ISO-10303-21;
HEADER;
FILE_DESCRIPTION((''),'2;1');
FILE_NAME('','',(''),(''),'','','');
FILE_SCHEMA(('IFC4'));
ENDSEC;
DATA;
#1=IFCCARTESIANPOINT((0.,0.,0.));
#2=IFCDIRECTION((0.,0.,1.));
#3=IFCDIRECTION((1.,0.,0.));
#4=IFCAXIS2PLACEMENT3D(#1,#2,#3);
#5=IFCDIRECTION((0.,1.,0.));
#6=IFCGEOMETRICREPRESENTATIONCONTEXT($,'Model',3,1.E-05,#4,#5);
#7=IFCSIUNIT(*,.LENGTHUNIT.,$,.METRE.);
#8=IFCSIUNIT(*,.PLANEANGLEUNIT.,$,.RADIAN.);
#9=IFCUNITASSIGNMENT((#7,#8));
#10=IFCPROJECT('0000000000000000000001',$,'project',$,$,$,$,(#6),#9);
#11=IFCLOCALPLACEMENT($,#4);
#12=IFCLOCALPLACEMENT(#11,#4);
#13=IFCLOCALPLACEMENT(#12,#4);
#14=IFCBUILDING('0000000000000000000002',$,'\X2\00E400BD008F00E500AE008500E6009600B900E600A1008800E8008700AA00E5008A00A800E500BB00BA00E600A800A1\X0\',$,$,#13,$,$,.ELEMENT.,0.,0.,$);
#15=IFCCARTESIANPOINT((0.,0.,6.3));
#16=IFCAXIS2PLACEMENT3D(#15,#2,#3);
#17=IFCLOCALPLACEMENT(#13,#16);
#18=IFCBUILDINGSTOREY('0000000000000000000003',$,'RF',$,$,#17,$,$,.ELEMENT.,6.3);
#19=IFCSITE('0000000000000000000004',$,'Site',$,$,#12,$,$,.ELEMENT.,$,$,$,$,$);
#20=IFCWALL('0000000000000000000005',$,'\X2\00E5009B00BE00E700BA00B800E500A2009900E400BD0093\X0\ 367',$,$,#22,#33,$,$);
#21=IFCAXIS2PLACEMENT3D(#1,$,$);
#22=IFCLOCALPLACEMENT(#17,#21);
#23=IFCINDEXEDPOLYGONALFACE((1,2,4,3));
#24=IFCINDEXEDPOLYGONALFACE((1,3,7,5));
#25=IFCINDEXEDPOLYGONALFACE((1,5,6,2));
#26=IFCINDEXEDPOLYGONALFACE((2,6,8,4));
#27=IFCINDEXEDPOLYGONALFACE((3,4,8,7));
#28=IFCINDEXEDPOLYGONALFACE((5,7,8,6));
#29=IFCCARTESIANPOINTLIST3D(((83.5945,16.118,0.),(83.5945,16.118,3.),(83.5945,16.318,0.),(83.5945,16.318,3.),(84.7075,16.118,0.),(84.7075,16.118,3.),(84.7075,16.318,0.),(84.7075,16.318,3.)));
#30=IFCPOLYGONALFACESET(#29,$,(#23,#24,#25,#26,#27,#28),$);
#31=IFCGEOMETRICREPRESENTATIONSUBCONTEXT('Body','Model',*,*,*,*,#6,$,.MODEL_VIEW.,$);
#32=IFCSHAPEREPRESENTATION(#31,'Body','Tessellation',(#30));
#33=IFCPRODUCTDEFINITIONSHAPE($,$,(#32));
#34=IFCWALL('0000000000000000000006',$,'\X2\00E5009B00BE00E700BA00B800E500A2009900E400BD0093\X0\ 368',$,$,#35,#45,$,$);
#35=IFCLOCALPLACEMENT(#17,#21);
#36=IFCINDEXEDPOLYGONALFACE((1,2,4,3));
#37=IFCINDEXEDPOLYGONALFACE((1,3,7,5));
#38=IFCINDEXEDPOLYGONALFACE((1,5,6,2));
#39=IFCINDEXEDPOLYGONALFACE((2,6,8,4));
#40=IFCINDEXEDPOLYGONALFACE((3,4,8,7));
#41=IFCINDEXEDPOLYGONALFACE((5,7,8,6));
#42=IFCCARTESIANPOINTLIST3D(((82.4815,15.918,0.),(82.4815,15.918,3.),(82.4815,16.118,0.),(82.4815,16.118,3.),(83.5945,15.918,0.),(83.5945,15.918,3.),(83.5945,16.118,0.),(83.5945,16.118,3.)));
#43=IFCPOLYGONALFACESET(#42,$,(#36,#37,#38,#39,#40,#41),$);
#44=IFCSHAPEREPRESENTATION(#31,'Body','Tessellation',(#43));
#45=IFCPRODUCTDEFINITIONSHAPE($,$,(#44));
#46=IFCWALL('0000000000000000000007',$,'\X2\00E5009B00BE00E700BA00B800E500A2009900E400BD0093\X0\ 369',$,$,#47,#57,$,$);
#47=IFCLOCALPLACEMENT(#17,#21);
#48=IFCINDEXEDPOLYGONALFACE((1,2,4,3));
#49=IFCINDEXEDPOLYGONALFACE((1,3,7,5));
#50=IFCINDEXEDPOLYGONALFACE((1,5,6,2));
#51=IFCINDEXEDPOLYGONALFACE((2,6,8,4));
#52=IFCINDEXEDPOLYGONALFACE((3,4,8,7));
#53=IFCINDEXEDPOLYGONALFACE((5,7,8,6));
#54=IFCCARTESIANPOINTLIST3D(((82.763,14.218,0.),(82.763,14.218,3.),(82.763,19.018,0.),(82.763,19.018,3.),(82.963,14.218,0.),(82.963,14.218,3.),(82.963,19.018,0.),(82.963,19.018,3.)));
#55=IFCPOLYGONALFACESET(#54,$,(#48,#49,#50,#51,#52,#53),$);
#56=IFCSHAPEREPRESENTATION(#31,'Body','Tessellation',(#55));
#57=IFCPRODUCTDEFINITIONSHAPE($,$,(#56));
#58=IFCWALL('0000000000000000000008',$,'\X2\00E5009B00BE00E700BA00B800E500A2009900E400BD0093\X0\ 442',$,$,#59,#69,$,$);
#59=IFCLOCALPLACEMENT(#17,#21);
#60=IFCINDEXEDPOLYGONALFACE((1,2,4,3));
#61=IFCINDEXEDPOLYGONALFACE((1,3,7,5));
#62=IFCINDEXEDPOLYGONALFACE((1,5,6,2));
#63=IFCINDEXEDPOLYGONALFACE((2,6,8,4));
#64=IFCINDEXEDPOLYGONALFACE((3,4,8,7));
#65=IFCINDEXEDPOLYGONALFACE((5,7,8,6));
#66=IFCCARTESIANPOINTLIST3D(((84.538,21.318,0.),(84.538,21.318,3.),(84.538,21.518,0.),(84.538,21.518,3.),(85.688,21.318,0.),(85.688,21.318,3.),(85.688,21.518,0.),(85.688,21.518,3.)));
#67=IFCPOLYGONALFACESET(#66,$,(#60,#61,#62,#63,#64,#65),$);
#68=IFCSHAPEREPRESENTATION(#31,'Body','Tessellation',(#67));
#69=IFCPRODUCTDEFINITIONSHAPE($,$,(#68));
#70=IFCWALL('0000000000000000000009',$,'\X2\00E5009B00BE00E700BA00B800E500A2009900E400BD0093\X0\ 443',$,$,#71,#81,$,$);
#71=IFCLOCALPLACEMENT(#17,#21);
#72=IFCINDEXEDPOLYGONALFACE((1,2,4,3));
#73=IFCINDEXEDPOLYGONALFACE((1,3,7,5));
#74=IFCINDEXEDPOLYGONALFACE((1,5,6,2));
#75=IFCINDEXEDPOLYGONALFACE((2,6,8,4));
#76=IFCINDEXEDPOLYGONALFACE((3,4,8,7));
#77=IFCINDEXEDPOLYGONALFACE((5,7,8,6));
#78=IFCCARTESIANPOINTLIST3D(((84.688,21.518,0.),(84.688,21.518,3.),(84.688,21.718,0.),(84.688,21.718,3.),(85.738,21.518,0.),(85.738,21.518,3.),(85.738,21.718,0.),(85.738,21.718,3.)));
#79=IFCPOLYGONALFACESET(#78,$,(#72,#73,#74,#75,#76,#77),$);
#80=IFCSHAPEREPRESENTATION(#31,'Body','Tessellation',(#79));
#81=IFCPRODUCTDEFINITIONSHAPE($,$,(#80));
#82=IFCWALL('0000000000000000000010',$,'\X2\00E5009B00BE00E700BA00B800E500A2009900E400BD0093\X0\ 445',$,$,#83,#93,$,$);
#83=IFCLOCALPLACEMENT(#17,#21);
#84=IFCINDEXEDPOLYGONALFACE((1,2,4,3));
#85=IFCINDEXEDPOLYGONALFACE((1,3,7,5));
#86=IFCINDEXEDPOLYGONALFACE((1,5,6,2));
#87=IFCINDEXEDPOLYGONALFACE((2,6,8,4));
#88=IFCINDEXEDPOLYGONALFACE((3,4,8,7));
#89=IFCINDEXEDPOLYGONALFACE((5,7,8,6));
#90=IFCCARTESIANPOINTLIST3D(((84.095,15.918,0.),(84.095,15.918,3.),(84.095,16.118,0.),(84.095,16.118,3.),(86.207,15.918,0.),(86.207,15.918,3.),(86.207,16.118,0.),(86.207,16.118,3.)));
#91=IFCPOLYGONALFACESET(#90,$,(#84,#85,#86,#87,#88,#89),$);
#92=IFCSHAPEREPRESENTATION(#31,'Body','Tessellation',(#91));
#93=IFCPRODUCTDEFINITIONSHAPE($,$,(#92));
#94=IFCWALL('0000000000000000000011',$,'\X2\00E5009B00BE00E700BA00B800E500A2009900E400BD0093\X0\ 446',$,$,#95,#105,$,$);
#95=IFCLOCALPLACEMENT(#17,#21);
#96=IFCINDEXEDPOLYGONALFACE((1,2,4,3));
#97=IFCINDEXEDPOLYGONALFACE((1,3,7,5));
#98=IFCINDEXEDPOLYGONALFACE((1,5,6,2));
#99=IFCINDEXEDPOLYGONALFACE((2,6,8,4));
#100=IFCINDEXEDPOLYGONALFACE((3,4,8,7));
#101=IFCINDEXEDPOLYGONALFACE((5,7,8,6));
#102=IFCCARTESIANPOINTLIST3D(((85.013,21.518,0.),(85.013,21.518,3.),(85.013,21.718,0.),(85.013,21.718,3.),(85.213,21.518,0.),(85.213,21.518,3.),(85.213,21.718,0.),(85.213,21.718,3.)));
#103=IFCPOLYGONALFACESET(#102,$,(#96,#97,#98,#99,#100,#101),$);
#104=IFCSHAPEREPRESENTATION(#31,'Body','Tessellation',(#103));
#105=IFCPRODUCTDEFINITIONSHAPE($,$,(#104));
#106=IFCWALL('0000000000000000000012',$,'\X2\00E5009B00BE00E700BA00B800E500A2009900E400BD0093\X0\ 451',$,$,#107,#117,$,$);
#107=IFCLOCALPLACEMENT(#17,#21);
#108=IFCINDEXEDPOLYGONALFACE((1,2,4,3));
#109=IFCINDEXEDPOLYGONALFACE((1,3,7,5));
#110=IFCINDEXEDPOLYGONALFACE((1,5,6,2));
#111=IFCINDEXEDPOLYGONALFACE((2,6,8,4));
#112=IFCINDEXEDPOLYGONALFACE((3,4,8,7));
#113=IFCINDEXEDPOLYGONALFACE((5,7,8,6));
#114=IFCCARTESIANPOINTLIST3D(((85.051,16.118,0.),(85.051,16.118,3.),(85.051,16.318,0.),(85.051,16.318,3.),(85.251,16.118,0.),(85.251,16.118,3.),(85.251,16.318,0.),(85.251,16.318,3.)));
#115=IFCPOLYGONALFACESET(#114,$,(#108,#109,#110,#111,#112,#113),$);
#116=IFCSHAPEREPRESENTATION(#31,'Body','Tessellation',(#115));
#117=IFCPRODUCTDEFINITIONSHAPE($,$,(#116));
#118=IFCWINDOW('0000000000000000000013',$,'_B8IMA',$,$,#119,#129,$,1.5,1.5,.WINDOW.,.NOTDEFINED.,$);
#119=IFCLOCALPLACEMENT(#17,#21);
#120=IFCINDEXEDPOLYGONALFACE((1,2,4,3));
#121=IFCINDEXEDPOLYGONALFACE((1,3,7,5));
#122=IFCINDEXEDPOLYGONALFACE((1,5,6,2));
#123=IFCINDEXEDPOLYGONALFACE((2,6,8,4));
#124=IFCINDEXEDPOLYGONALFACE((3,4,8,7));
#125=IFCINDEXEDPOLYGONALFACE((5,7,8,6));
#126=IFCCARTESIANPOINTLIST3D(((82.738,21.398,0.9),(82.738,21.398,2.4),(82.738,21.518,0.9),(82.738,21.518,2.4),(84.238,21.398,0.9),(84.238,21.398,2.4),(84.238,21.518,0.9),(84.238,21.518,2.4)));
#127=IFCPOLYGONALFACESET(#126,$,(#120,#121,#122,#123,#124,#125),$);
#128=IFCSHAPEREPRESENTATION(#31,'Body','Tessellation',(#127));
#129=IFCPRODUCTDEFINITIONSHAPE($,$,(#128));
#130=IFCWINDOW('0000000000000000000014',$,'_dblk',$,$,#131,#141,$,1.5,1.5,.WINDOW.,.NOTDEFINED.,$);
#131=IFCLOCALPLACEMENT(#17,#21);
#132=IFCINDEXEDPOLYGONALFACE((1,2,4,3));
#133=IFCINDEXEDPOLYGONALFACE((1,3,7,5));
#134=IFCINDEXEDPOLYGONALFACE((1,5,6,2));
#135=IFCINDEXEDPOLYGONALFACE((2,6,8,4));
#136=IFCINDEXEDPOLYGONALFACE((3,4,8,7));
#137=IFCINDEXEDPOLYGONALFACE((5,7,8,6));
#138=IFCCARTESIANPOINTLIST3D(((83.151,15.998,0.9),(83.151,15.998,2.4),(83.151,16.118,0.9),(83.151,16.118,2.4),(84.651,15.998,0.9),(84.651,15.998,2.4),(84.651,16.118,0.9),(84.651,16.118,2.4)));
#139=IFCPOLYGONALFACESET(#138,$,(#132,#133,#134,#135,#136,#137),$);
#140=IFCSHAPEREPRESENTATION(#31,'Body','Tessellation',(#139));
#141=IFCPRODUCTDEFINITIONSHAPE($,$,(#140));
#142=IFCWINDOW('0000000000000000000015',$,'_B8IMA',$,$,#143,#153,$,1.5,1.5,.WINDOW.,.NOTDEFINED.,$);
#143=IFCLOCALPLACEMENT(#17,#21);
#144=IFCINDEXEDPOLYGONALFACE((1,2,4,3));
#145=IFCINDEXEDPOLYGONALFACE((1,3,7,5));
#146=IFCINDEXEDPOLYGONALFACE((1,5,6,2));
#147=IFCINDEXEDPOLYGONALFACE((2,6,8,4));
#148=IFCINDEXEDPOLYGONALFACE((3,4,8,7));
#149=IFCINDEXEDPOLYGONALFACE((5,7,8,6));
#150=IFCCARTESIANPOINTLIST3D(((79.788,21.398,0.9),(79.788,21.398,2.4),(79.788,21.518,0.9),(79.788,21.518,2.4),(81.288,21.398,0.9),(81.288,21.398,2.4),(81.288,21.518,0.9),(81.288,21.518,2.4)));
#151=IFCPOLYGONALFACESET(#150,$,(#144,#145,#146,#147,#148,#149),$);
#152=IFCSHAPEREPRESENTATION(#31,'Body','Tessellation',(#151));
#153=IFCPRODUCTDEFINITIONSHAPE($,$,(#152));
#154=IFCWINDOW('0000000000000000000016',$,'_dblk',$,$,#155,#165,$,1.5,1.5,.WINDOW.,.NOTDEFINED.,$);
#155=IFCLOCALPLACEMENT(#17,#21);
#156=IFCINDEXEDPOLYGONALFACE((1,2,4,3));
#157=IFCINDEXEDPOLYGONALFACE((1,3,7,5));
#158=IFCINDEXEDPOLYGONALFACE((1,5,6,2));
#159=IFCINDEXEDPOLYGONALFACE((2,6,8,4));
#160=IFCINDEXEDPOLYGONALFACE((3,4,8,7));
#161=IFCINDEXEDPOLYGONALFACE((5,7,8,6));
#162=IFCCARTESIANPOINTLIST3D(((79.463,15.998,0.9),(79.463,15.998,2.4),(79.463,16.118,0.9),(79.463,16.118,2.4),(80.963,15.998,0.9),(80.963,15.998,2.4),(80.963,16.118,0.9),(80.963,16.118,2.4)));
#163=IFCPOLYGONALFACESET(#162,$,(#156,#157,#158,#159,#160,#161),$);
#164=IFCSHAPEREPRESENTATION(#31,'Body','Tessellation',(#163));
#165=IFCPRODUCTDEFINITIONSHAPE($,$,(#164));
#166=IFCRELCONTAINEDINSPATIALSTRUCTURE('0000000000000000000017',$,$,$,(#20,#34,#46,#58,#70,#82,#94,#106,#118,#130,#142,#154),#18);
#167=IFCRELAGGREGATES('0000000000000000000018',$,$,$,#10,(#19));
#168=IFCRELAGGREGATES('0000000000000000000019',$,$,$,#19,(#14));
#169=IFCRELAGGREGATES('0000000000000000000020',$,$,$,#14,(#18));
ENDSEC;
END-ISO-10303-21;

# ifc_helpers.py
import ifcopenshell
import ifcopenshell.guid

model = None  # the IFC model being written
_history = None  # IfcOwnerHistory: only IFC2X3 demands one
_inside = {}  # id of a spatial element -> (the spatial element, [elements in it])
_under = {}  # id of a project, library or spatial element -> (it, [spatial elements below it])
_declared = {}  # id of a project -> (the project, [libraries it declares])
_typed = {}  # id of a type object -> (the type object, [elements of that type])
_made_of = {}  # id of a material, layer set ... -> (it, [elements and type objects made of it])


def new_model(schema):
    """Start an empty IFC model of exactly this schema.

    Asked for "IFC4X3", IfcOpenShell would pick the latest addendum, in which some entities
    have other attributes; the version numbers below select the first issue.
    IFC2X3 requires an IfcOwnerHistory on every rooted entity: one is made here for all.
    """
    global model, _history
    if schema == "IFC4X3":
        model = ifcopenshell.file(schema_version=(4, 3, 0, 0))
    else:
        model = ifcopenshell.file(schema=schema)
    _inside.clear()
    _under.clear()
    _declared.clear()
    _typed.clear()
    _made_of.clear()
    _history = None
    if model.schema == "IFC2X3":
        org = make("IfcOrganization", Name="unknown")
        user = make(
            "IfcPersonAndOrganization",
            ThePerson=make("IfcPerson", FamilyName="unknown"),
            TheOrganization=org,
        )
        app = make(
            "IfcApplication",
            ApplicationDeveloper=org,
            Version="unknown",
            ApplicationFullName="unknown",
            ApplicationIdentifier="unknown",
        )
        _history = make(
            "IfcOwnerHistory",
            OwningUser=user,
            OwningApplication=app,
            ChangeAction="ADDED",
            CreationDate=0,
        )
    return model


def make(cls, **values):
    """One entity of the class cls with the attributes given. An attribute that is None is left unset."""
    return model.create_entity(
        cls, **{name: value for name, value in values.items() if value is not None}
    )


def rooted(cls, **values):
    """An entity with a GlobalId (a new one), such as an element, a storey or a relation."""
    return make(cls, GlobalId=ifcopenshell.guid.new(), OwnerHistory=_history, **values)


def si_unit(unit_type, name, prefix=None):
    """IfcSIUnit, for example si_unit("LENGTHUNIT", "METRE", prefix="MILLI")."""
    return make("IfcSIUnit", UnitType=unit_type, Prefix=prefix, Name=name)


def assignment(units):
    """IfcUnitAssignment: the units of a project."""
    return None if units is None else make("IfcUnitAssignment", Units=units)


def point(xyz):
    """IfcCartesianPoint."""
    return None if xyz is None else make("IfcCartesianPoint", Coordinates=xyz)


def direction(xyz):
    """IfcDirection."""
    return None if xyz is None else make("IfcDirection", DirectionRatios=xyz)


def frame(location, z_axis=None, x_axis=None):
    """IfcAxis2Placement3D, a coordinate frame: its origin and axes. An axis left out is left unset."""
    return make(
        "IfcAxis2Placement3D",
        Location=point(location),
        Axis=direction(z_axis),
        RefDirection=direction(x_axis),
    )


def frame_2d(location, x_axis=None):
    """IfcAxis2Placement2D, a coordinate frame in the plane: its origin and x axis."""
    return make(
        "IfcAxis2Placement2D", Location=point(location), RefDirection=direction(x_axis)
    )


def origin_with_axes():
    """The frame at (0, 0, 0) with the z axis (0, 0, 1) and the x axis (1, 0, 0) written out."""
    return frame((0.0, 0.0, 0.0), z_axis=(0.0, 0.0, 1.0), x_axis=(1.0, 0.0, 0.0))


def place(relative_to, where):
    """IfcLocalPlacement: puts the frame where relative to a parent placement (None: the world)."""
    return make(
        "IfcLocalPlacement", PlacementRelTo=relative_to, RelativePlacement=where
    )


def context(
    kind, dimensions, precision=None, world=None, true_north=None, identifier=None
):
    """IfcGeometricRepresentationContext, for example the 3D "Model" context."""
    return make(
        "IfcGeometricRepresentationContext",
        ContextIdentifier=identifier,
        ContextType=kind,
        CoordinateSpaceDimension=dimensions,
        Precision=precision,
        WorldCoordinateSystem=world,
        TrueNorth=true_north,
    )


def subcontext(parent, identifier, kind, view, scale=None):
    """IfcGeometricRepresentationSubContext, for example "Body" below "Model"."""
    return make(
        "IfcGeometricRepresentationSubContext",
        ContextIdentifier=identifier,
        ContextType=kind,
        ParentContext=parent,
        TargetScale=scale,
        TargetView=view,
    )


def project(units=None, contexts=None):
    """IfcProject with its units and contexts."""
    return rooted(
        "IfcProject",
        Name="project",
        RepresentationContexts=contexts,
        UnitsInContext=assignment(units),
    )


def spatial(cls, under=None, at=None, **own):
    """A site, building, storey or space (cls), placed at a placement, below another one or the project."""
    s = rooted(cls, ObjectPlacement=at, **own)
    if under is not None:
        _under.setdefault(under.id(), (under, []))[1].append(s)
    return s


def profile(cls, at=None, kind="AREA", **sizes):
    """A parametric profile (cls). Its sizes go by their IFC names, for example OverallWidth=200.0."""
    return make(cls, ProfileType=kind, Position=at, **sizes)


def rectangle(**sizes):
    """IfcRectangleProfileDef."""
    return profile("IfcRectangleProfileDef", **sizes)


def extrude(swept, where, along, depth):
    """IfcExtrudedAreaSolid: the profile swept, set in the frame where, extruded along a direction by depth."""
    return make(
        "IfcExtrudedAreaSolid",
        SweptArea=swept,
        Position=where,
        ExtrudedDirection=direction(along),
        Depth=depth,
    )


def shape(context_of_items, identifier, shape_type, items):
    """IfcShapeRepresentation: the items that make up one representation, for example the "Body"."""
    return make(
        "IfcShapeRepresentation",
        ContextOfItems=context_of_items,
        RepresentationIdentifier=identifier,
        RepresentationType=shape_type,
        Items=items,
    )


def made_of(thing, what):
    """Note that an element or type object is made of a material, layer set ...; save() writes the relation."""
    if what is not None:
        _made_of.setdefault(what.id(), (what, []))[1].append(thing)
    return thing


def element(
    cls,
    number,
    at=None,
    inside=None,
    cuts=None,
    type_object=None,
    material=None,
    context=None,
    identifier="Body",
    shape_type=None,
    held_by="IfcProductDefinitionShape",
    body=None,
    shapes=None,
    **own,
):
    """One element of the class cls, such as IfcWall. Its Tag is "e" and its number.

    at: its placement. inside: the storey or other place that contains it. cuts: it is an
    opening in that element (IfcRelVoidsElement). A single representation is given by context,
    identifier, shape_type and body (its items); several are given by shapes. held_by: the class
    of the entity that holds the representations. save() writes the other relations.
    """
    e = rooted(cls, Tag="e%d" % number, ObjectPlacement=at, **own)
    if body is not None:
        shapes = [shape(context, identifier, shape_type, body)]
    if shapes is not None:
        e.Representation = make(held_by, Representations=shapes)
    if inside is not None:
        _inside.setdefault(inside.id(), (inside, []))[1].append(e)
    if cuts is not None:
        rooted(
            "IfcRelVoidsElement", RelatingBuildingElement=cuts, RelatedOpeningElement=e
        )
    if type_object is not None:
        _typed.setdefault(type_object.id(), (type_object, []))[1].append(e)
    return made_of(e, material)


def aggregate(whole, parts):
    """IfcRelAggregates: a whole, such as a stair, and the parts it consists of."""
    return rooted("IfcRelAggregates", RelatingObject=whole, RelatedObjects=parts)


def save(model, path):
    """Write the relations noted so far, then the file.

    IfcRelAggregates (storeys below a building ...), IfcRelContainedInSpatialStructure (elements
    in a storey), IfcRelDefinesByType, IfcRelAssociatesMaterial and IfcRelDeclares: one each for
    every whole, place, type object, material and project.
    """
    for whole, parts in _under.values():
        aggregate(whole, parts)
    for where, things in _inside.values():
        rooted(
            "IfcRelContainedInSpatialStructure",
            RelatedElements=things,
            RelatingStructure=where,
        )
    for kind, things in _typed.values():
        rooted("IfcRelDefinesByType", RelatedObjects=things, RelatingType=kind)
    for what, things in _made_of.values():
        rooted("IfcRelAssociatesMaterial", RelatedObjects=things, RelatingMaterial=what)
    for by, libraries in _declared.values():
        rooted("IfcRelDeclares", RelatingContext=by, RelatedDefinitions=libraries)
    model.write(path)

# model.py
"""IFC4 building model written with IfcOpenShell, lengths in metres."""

from ifc_helpers import new_model, si_unit, direction, frame, frame_2d, origin_with_axes, place, context, subcontext, project, spatial, rectangle, extrude, element, save


model = new_model("IFC4")

# Units and contexts
model_context = context("Model", 3, precision=1e-05, world=origin_with_axes(), true_north=direction((0.0, 1.0, 0.0)))
body_context = subcontext(model_context, "Body", "Model", "MODEL_VIEW")
ifc_project = project(units=[si_unit("LENGTHUNIT", "METRE"), si_unit("PLANEANGLEUNIT", "RADIAN")], contexts=[model_context])

# Site, building, storey
placement = place(None, origin_with_axes())
site_placement = place(placement, origin_with_axes())
site = spatial("IfcSite", under=ifc_project, at=site_placement, Name="Site", CompositionType="ELEMENT")
building_placement = place(site_placement, origin_with_axes())
building = spatial("IfcBuilding", under=site, at=building_placement, Name="ä½\u008få®\u0085æ\u0096¹æ¡\u0088è\u0087ªå\u008a¨å»ºæ¨¡", CompositionType="ELEMENT", ElevationOfRefHeight=0.0, ElevationOfTerrain=0.0)
storey_placement = place(building_placement, frame((0.0, 0.0, 6.3), z_axis=(0.0, 0.0, 1.0), x_axis=(1.0, 0.0, 0.0)))
storey = spatial("IfcBuildingStorey", under=building, at=storey_placement, Name="RF", CompositionType="ELEMENT", Elevation=6.3)

# Walls
for number, where, z_axis, x_axis, name in (
    (1, (84.151, 16.218, 0.0), (0.0, 0.0, 1.0), (-1.0, 0.0, 0.0), "å\u009b¾çº¸å¢\u0099ä½\u0093 367"),
    (2, (83.038, 16.018, 0.0), (0.0, 0.0, 1.0), (1.0, 0.0, 0.0), "å\u009b¾çº¸å¢\u0099ä½\u0093 368"),
):
    element("IfcWall", number, at=place(storey_placement, frame(where, z_axis=z_axis, x_axis=x_axis)), inside=storey, Name=name, context=body_context, shape_type="SweptSolid", body=[
        extrude(rectangle(XDim=1.113, YDim=0.2, at=frame_2d((0.0, 0.0), x_axis=(1.0, 0.0, 0.0))), frame((0.0, 0.0, 0.0), z_axis=(0.0, 0.0, 1.0)), (0.0, 0.0, 1.0), 3.0),
    ])
wall_1_placement = place(storey_placement, frame((82.863, 16.618, 0.0), z_axis=(0.0, 0.0, 1.0), x_axis=(0.0, 1.0, 0.0)))
element("IfcWall", 3, at=wall_1_placement, inside=storey, Name="å\u009b¾çº¸å¢\u0099ä½\u0093 369", context=body_context, shape_type="SweptSolid", body=[
    extrude(rectangle(XDim=4.8, YDim=0.2, at=frame_2d((0.0, 0.0), x_axis=(1.0, 0.0, 0.0))), frame((0.0, 0.0, 0.0), z_axis=(0.0, 0.0, 1.0)), (0.0, 0.0, 1.0), 3.0),
])
wall_2_placement = place(storey_placement, frame((85.113, 21.418, 0.0), z_axis=(0.0, 0.0, 1.0), x_axis=(1.0, 0.0, 0.0)))
element("IfcWall", 4, at=wall_2_placement, inside=storey, Name="å\u009b¾çº¸å¢\u0099ä½\u0093 442", context=body_context, shape_type="SweptSolid", body=[
    extrude(rectangle(XDim=1.15, YDim=0.2, at=frame_2d((0.0, 0.0), x_axis=(1.0, 0.0, 0.0))), frame((0.0, 0.0, 0.0), z_axis=(0.0, 0.0, 1.0)), (0.0, 0.0, 1.0), 3.0),
])
wall_3_placement = place(storey_placement, frame((85.213, 21.618, 0.0), z_axis=(0.0, 0.0, 1.0), x_axis=(1.0, 0.0, 0.0)))
element("IfcWall", 5, at=wall_3_placement, inside=storey, Name="å\u009b¾çº¸å¢\u0099ä½\u0093 443", context=body_context, shape_type="SweptSolid", body=[
    extrude(rectangle(XDim=1.05, YDim=0.2, at=frame_2d((0.0, 0.0), x_axis=(1.0, 0.0, 0.0))), frame((0.0, 0.0, 0.0), z_axis=(0.0, 0.0, 1.0)), (0.0, 0.0, 1.0), 3.0),
])
wall_4_placement = place(storey_placement, frame((85.151, 16.018, 0.0), z_axis=(0.0, 0.0, 1.0), x_axis=(1.0, 0.0, 0.0)))
element("IfcWall", 6, at=wall_4_placement, inside=storey, Name="å\u009b¾çº¸å¢\u0099ä½\u0093 445", context=body_context, shape_type="SweptSolid", body=[
    extrude(rectangle(XDim=2.112, YDim=0.2, at=frame_2d((0.0, 0.0), x_axis=(1.0, 0.0, 0.0))), frame((0.0, 0.0, 0.0), z_axis=(0.0, 0.0, 1.0)), (0.0, 0.0, 1.0), 3.0),
])
for number, where, z_axis, x_axis, name in (
    (7, (85.113, 21.618, 0.0), (0.0, 0.0, 1.0), (0.0, -1.0, 0.0), "å\u009b¾çº¸å¢\u0099ä½\u0093 446"),
    (8, (85.151, 16.218, 0.0), (0.0, 0.0, 1.0), (0.0, -1.0, 0.0), "å\u009b¾çº¸å¢\u0099ä½\u0093 451"),
):
    element("IfcWall", number, at=place(storey_placement, frame(where, z_axis=z_axis, x_axis=x_axis)), inside=storey, Name=name, context=body_context, shape_type="SweptSolid", body=[
        extrude(rectangle(XDim=0.2, YDim=0.2, at=frame_2d((0.0, 0.0), x_axis=(1.0, 0.0, 0.0))), frame((0.0, 0.0, 0.0), z_axis=(0.0, 0.0, 1.0)), (0.0, 0.0, 1.0), 3.0),
    ])

# Windows
for number, where, z_axis, x_axis, name in (
    (9, (83.488, 21.458, 0.9), (0.0, 0.0, 1.0), (1.0, 0.0, 0.0), "_B8IMA"),
    (10, (83.901, 16.058, 0.9), (0.0, 0.0, 1.0), (1.0, 0.0, 0.0), "_dblk"),
    (11, (80.538, 21.458, 0.9), (0.0, 0.0, 1.0), (1.0, 0.0, 0.0), "_B8IMA"),
    (12, (80.213, 16.058, 0.9), (0.0, 0.0, 1.0), (1.0, 0.0, 0.0), "_dblk"),
):
    element("IfcWindow", number, at=place(storey_placement, frame(where, z_axis=z_axis, x_axis=x_axis)), inside=storey, Name=name, OverallHeight=1.5, OverallWidth=1.5, PartitioningType="NOTDEFINED", PredefinedType="WINDOW", context=body_context, shape_type="SweptSolid", body=[
        extrude(rectangle(XDim=1.5, YDim=0.12, at=frame_2d((0.0, 0.0), x_axis=(1.0, 0.0, 0.0))), frame((0.0, 0.0, 0.0), z_axis=(0.0, 0.0, 1.0)), (0.0, 0.0, 1.0), 1.5),
    ])

save(model, "model.ifc")
